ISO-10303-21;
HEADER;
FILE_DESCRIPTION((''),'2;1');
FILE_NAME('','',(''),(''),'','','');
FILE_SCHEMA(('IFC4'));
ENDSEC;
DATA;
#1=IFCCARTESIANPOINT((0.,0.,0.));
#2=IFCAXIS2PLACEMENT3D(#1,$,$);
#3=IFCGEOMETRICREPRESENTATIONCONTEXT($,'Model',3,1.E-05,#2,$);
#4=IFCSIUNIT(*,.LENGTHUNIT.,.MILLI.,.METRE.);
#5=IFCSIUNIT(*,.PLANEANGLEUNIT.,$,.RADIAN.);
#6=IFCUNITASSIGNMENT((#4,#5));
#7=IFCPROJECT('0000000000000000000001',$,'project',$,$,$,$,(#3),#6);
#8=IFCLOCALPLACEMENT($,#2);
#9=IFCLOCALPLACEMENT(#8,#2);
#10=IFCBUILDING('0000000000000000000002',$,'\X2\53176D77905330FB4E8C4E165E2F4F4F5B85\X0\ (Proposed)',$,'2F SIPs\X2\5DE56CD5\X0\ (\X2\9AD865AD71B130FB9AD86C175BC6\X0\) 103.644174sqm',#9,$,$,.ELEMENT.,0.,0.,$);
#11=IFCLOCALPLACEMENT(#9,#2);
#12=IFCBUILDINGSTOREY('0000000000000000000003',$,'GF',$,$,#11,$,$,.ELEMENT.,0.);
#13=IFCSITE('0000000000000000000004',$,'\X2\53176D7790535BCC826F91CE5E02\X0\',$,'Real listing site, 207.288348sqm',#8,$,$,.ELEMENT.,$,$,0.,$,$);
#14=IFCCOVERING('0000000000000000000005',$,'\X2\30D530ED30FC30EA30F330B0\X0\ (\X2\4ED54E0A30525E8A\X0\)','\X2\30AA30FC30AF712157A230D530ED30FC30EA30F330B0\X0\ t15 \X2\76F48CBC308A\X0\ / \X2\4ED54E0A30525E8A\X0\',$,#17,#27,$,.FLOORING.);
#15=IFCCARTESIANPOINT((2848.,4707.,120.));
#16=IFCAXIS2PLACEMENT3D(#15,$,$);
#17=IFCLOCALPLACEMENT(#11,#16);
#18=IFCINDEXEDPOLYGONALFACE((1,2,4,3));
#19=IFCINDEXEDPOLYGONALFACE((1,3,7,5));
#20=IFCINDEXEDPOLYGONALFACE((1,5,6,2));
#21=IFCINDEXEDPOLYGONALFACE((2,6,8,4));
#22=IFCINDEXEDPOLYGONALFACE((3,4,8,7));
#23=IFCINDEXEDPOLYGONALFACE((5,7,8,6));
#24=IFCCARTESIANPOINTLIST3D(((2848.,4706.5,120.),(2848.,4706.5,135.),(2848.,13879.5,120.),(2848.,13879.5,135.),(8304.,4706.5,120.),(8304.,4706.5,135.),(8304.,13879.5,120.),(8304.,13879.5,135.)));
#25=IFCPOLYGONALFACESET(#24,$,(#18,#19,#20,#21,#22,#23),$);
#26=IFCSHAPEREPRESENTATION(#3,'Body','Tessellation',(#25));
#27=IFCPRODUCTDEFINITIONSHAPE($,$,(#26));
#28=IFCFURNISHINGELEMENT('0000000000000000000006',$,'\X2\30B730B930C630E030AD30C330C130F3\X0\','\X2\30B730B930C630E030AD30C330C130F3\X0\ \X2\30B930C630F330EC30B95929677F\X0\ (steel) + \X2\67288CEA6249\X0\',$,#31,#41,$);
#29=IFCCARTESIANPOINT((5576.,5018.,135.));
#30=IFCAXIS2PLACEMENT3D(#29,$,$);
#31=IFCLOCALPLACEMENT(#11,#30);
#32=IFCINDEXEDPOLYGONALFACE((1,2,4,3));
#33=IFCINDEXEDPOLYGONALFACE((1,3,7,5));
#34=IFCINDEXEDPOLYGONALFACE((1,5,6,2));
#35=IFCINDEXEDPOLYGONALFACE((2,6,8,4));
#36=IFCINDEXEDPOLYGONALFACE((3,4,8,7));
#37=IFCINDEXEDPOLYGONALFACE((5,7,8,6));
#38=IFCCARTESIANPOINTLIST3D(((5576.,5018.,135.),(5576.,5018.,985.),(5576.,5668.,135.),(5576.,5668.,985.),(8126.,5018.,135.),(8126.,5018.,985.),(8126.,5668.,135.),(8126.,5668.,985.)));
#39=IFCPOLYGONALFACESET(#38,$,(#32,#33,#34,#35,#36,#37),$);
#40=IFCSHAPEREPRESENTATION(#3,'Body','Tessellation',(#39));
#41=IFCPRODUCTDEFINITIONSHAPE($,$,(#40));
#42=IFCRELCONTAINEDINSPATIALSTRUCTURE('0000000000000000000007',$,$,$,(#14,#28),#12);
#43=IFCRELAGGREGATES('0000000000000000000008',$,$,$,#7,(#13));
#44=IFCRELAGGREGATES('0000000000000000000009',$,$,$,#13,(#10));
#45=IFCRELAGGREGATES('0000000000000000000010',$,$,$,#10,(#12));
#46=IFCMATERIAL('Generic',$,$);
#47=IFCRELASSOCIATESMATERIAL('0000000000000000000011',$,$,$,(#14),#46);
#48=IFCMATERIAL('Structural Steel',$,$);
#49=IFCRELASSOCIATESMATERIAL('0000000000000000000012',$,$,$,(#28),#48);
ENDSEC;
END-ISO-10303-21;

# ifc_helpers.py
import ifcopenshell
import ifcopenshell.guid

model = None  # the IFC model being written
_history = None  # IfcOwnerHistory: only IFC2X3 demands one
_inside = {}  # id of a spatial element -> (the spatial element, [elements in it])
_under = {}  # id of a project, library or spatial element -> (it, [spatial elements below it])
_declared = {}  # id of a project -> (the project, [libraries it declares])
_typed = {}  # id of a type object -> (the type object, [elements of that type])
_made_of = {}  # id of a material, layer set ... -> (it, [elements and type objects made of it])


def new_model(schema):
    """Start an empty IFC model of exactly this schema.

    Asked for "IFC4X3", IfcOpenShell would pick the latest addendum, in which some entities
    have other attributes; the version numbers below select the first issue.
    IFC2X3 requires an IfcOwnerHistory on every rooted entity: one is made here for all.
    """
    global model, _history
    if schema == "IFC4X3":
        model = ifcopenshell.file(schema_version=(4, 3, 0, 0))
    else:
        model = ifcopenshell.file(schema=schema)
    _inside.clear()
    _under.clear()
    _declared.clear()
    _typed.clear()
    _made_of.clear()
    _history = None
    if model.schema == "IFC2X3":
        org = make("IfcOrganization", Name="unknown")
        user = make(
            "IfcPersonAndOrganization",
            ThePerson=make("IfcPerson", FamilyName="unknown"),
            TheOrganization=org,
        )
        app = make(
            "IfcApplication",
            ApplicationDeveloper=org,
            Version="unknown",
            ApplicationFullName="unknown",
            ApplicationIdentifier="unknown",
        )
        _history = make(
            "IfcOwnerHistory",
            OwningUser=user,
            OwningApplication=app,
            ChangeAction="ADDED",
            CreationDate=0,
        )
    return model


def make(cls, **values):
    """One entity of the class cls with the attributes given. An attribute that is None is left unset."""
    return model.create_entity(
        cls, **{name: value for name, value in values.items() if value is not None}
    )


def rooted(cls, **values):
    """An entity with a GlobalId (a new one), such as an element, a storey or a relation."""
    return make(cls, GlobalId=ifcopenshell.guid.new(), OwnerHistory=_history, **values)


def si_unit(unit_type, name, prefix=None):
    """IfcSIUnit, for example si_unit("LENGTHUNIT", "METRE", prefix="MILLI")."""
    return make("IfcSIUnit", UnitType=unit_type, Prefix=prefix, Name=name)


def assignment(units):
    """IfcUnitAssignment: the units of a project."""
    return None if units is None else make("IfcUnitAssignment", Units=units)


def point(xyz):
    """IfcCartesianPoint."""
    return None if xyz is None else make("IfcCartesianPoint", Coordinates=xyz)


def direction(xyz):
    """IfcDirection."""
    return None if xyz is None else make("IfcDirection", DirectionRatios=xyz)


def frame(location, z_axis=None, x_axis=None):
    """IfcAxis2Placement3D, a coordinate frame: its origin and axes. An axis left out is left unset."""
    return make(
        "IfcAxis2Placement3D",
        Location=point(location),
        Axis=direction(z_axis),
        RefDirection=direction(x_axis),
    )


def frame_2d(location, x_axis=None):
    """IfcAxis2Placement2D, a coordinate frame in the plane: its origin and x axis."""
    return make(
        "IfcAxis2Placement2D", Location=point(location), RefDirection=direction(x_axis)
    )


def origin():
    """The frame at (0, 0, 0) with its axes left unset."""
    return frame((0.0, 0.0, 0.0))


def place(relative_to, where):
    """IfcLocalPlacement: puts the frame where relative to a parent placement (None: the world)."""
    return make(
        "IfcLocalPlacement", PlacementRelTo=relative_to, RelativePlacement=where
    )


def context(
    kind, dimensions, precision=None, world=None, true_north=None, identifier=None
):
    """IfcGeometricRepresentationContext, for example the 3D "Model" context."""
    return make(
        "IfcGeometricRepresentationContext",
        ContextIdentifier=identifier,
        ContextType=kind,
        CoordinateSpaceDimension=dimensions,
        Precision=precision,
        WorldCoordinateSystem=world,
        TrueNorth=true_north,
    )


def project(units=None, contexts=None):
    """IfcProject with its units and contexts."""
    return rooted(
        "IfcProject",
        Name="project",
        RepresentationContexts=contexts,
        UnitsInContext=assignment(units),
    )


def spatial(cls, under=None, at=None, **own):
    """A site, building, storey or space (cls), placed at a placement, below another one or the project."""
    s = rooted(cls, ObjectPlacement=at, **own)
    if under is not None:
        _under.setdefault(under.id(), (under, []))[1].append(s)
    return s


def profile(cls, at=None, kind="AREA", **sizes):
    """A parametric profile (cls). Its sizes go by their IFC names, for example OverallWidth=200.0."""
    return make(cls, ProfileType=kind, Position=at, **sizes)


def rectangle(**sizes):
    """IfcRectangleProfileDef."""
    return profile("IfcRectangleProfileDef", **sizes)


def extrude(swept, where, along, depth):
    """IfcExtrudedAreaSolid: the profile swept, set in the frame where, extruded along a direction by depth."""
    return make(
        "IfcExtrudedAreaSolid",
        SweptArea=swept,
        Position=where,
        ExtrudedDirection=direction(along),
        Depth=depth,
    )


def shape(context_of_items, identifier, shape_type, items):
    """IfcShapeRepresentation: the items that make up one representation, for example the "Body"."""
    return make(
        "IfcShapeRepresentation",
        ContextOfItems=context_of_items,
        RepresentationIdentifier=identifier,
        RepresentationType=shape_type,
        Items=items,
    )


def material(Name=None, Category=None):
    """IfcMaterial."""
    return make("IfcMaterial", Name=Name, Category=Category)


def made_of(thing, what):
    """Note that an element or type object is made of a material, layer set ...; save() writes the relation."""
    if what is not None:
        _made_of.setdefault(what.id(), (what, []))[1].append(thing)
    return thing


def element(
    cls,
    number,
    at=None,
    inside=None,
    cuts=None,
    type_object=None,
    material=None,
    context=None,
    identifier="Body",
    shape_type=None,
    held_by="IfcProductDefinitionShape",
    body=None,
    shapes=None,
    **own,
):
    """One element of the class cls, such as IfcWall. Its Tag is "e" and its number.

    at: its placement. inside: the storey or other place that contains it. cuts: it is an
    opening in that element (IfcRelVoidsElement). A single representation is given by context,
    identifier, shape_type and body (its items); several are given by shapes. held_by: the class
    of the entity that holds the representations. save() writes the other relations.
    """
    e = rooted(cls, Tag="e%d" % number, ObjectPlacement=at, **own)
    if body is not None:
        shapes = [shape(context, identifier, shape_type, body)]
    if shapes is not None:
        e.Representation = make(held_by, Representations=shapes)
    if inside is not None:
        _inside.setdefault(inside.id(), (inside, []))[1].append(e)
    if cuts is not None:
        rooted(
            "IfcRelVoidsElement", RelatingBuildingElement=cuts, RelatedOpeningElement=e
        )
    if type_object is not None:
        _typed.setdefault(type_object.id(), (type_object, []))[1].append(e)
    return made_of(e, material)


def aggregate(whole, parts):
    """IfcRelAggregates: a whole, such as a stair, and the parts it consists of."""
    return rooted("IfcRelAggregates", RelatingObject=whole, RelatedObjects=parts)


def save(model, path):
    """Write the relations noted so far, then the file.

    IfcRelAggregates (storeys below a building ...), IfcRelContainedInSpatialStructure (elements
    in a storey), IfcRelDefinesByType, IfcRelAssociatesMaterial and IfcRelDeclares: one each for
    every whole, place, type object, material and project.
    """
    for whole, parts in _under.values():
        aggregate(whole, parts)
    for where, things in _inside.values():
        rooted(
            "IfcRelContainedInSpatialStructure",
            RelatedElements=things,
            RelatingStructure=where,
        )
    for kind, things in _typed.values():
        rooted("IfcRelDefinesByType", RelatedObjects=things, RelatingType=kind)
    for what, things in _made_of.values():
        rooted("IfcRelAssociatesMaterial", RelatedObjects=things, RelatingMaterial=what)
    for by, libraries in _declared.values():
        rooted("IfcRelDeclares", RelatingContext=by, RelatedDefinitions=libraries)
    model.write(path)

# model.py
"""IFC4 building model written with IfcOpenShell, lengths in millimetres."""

from ifc_helpers import new_model, si_unit, frame, frame_2d, origin, place, context, project, spatial, rectangle, extrude, material, element, save


model = new_model("IFC4")

# Units and contexts
model_context = context("Model", 3, precision=1e-05, world=origin())
ifc_project = project(units=[si_unit("LENGTHUNIT", "METRE", prefix="MILLI"), si_unit("PLANEANGLEUNIT", "RADIAN")], contexts=[model_context])

# Site, building, storey
site_placement = place(None, origin())
site = spatial("IfcSite", under=ifc_project, at=site_placement, Name="北海道富良野市", ObjectType="Real listing site, 207.288348sqm", CompositionType="ELEMENT", RefElevation=0.0)
building_placement = place(site_placement, origin())
building = spatial("IfcBuilding", under=site, at=building_placement, Name="北海道・二世帯住宅 (Proposed)", ObjectType="2F SIPs工法 (高断熱・高気密) 103.644174sqm", CompositionType="ELEMENT", ElevationOfRefHeight=0.0, ElevationOfTerrain=0.0)
storey_placement = place(building_placement, origin())
storey = spatial("IfcBuildingStorey", under=building, at=storey_placement, Name="GF", CompositionType="ELEMENT", Elevation=0.0)

# Covering
ifc_material_1 = material(Name="Generic")
covering_placement = place(storey_placement, frame((2848.0, 4707.0, 120.0)))
element("IfcCovering", 1, at=covering_placement, inside=storey, material=ifc_material_1, Name="フローリング (仕上げ床)", Description="オーク無垢フローリング t15 直貼り / 仕上げ床", PredefinedType="FLOORING", context=model_context, shape_type="SweptSolid", body=[
    extrude(rectangle(XDim=5456.0, YDim=9173.0, at=frame_2d((2728.0, 4586.0))), frame((2848.0, 4707.0, 120.0)), (0.0, 0.0, 1.0), 15.0),
])

# Furnishing element
ifc_material_2 = material(Name="Structural Steel")
furnishing_placement = place(storey_placement, frame((5576.0, 5018.0, 135.0)))
element("IfcFurnishingElement", 2, at=furnishing_placement, inside=storey, material=ifc_material_2, Name="システムキッチン", Description="システムキッチン ステンレス天板 (steel) + 木質扉", context=model_context, shape_type="SweptSolid", body=[
    extrude(rectangle(XDim=2550.0, YDim=650.0, at=frame_2d((1275.0, 325.0))), frame((5576.0, 5018.0, 135.0)), (0.0, 0.0, 1.0), 850.0),
])

save(model, "model.ifc")
